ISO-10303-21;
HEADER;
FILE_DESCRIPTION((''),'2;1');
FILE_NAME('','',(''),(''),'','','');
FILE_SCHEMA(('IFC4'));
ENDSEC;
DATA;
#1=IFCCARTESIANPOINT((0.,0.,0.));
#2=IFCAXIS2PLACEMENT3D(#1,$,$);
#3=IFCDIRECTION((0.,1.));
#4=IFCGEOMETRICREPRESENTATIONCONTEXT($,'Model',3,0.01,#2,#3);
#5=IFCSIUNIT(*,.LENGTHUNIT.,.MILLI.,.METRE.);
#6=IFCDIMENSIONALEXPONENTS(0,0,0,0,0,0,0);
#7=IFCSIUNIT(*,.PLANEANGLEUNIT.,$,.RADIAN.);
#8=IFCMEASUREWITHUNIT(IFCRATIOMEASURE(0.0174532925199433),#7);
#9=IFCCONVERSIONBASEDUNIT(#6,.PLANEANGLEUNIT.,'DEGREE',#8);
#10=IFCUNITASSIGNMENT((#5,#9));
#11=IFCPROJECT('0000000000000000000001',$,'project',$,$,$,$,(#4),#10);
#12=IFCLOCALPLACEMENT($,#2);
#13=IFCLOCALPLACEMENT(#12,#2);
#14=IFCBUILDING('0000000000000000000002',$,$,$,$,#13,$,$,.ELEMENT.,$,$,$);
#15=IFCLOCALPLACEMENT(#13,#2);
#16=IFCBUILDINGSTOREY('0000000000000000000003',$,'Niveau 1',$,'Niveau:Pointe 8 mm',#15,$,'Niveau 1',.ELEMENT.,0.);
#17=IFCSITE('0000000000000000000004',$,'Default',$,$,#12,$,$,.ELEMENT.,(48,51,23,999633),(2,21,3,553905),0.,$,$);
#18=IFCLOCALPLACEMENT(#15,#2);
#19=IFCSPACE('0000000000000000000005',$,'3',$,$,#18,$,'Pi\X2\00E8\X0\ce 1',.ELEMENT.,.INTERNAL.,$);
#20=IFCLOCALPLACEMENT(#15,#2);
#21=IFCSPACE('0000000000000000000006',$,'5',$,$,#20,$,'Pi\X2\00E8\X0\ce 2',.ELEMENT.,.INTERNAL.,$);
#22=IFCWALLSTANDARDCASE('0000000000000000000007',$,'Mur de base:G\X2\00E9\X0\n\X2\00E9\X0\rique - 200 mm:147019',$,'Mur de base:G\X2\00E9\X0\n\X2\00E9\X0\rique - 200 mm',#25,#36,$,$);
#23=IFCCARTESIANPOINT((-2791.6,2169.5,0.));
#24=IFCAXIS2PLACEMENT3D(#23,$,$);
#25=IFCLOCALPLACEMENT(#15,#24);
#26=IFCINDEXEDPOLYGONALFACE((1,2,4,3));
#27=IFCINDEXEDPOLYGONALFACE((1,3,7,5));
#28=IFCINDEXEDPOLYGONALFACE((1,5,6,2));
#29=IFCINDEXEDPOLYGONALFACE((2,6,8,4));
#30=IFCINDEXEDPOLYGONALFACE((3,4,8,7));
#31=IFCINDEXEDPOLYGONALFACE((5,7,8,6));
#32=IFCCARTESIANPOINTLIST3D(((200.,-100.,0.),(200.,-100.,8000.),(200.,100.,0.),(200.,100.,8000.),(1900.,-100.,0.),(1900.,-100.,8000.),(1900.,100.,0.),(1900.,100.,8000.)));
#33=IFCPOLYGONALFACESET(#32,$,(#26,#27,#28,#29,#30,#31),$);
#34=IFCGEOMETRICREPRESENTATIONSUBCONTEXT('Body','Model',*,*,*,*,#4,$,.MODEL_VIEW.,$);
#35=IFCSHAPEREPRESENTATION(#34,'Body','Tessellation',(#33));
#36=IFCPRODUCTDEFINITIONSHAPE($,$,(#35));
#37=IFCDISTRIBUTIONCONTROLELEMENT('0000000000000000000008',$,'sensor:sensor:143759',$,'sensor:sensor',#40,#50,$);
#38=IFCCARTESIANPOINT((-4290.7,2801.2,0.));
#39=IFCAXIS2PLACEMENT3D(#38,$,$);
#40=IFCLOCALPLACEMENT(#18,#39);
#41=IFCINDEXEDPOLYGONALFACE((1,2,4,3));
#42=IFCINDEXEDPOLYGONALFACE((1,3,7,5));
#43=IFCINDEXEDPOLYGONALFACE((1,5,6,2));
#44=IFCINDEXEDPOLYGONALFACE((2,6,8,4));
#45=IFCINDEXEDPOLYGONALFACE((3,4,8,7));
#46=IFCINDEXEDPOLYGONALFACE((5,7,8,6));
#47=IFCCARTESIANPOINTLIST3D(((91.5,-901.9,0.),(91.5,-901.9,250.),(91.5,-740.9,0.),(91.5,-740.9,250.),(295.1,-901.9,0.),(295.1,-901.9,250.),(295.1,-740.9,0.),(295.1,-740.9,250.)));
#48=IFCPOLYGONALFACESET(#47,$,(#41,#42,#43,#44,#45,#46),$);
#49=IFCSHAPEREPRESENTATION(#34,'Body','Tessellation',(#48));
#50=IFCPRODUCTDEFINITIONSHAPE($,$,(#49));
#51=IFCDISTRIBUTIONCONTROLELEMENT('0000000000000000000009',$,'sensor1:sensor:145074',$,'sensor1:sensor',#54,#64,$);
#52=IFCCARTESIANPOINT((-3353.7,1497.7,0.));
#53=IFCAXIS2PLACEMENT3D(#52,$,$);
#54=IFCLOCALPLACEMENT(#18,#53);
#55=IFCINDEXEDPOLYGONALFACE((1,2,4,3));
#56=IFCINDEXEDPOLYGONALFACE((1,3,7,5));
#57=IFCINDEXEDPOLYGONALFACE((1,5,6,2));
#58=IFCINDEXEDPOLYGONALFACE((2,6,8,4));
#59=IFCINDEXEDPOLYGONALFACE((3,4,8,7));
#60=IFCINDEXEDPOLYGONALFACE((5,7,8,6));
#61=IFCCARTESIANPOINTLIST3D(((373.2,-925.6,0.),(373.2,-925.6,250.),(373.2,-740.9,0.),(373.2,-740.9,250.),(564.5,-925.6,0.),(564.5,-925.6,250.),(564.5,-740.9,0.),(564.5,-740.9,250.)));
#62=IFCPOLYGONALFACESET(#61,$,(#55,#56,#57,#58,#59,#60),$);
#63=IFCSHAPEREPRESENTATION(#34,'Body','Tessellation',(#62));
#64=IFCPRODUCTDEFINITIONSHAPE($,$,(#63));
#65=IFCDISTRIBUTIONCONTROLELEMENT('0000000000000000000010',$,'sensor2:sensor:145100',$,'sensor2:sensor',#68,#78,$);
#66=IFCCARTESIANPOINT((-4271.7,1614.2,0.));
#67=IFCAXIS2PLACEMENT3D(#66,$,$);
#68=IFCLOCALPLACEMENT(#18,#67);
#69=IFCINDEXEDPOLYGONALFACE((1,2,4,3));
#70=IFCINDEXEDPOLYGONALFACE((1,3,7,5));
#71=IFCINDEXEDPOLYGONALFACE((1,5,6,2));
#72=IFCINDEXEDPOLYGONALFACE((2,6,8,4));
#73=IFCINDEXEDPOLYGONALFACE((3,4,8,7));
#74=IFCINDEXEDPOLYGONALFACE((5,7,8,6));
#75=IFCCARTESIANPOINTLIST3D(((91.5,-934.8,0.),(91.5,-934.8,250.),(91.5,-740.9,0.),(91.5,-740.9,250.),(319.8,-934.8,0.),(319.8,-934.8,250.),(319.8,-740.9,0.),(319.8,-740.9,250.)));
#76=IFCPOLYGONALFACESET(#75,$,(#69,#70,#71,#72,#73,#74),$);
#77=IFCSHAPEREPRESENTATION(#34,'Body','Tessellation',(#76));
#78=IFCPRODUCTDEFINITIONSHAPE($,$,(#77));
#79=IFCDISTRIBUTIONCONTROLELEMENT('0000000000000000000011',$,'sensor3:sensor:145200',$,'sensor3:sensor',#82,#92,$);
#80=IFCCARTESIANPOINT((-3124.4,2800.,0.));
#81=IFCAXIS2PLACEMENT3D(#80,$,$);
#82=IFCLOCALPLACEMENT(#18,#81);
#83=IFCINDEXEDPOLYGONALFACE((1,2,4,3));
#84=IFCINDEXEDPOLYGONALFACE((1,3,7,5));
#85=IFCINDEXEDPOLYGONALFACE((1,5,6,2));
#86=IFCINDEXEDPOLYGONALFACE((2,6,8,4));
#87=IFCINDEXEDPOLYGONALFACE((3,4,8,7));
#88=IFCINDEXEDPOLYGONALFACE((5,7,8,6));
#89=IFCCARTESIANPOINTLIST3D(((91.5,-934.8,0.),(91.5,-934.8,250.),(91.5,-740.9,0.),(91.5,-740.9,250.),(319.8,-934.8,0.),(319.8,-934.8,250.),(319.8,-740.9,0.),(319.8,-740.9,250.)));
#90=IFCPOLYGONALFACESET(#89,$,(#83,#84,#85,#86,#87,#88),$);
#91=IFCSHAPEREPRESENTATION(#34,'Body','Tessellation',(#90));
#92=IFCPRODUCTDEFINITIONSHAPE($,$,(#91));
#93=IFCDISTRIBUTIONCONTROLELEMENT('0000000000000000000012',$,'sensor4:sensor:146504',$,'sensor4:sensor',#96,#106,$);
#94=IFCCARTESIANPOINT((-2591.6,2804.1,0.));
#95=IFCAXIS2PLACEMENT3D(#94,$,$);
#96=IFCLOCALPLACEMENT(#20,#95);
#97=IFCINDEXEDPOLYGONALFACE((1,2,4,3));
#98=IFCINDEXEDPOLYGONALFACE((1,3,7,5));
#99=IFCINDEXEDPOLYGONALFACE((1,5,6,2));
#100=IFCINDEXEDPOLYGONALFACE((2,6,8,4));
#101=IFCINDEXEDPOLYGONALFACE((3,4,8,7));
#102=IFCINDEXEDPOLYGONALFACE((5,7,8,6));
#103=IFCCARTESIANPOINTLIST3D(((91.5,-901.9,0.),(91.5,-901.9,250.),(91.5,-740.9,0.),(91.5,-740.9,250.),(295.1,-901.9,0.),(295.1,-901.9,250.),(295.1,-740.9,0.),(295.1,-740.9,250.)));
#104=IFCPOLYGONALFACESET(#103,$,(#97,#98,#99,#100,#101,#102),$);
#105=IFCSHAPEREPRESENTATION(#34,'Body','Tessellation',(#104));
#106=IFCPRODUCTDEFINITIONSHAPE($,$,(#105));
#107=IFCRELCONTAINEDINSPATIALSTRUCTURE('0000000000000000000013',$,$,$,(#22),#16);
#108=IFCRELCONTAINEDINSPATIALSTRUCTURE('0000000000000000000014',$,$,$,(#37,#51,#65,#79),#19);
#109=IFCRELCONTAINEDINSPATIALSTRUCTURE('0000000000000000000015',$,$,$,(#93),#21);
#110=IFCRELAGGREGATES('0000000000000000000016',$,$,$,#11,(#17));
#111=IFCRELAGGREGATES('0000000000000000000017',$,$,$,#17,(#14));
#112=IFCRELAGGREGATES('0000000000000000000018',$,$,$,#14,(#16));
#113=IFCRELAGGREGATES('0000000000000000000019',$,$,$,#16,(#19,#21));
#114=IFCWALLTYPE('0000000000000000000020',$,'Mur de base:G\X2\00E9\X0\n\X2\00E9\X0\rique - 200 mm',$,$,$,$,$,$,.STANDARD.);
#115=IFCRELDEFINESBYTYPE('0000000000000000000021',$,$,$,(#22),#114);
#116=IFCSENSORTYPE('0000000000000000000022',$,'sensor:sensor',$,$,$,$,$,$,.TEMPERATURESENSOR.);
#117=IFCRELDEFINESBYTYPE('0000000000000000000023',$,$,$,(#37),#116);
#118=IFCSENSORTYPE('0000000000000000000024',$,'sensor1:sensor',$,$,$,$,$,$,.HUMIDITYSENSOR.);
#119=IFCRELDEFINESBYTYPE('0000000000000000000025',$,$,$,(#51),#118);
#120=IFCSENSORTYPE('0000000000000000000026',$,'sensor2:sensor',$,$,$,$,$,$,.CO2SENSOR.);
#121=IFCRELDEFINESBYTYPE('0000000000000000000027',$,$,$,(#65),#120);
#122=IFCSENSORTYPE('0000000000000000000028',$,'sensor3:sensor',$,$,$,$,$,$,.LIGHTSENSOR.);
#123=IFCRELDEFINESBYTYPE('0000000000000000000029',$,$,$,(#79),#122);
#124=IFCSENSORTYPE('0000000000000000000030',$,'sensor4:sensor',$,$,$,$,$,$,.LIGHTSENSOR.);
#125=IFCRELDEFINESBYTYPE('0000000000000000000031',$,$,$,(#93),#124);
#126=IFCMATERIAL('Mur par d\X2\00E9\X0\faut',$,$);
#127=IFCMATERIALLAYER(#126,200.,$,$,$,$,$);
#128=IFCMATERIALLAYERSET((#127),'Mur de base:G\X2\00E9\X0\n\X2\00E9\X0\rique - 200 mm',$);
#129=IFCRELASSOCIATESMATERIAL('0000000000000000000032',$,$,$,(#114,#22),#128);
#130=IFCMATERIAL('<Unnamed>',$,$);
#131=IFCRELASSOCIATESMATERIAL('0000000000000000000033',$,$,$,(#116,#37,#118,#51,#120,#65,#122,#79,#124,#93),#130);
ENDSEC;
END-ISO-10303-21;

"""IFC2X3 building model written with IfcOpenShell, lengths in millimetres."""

from ifc_helpers import new_model, entity, si_unit, converted_unit, direction, frame, frame_2d, origin, origin_2d_with_axis, place, context, subcontext, project, spatial, rectangle, extrude, source, transform, mapped, material, layer, layer_set, layer_usage, type_object, type_shapes, element, save


model = new_model("IFC2X3")

# Units and contexts
model_context = context("Model", 3, precision=0.01, world=origin(), true_north=direction((0.0, 1.0)))
body_context = subcontext(model_context, "Body", "Model", "MODEL_VIEW")
ifc_project = project(units=[si_unit("LENGTHUNIT", "METRE", prefix="MILLI"), converted_unit("PLANEANGLEUNIT", "DEGREE", entity("IfcRatioMeasure", 0.0174532925199433), si_unit("PLANEANGLEUNIT", "RADIAN"), dimensions=[0, 0, 0, 0, 0, 0, 0])], contexts=[model_context])

# Site, building, storey
site_placement = place(None, origin())
site = spatial("IfcSite", under=ifc_project, at=site_placement, Name="Default", CompositionType="ELEMENT", RefLatitude=(48, 51, 23, 999633), RefLongitude=(2, 21, 3, 553905), RefElevation=0.0)
building_placement = place(site_placement, origin())
building = spatial("IfcBuilding", under=site, at=building_placement, CompositionType="ELEMENT")
storey_placement = place(building_placement, origin())
storey = spatial("IfcBuildingStorey", under=building, at=storey_placement, Name="Niveau 1", ObjectType="Niveau:Pointe 8 mm", LongName="Niveau 1", CompositionType="ELEMENT", Elevation=0.0)

# Wall
ifc_material_1 = material(Name="Mur par défaut")
ifc_layer_1 = layer(ifc_material_1, 200.0)
ifc_layer_set_1 = layer_set([ifc_layer_1], Name="Mur de base:Générique - 200 mm")
wall_type = type_object("IfcWallType", Name="Mur de base:Générique - 200 mm", PredefinedType="STANDARD", material=ifc_layer_set_1)
ifc_layer_usage_1 = layer_usage(ifc_layer_set_1, "AXIS2", "NEGATIVE", 100.0)
wall_1_placement = place(storey_placement, frame((-2791.6, 2169.5, 0.0)))
element("IfcWallStandardCase", 1, at=wall_1_placement, inside=storey, type_object=wall_type, material=ifc_layer_usage_1, Name="Mur de base:Générique - 200 mm:147019", ObjectType="Mur de base:Générique - 200 mm", context=body_context, shape_type="SweptSolid", body=[
    extrude(rectangle(XDim=1700.0, YDim=200.0, at=frame_2d((1050.0, 0.0), x_axis=(-1.0, 0.0))), origin(), (0.0, 0.0, 1.0), 8000.0),
])

# Shared definitions
space_1_placement = place(storey_placement, origin())
space_1 = spatial("IfcSpace", under=storey, at=space_1_placement, Name="3", LongName="Pièce 1", CompositionType="ELEMENT", InteriorOrExteriorSpace="INTERNAL")

# Distribution control elements
ifc_material_2 = material(Name="<Unnamed>")
sensor_type_1 = type_object("IfcSensorType", Name="sensor:sensor", PredefinedType="TEMPERATURESENSOR", material=ifc_material_2)
shared_shape_1 = source(origin(), body_context, "Body", "SweptSolid", [
    extrude(rectangle(XDim=203.6, YDim=161.0, at=origin_2d_with_axis()), frame((193.3, -821.4, 0.0), z_axis=(0.0, 0.0, 1.0), x_axis=(-1.0, 0.0, 0.0)), (0.0, 0.0, 1.0), 250.0),
])
type_shapes(sensor_type_1, [shared_shape_1])
distribution_control_element_1_placement = place(space_1_placement, frame((-4290.7, 2801.2, 0.0)))
element("IfcDistributionControlElement", 2, at=distribution_control_element_1_placement, inside=space_1, type_object=sensor_type_1, material=ifc_material_2, Name="sensor:sensor:143759", ObjectType="sensor:sensor", context=body_context, shape_type="MappedRepresentation", body=[
    mapped(shared_shape_1, transform((0.0, 0.0, 0.0), scale=1.0)),
])
sensor_type_2 = type_object("IfcSensorType", Name="sensor1:sensor", PredefinedType="HUMIDITYSENSOR", material=ifc_material_2)
shared_shape_2 = source(origin(), body_context, "Body", "SweptSolid", [
    extrude(rectangle(XDim=191.3, YDim=184.7, at=origin_2d_with_axis()), frame((468.8, -833.2, 0.0), z_axis=(0.0, 0.0, 1.0), x_axis=(-1.0, 0.0, 0.0)), (0.0, 0.0, 1.0), 250.0),
])
type_shapes(sensor_type_2, [shared_shape_2])
distribution_control_element_2_placement = place(space_1_placement, frame((-3353.7, 1497.7, 0.0)))
element("IfcDistributionControlElement", 3, at=distribution_control_element_2_placement, inside=space_1, type_object=sensor_type_2, material=ifc_material_2, Name="sensor1:sensor:145074", ObjectType="sensor1:sensor", context=body_context, shape_type="MappedRepresentation", body=[
    mapped(shared_shape_2, transform((0.0, 0.0, 0.0), scale=1.0)),
])
sensor_type_3 = type_object("IfcSensorType", Name="sensor2:sensor", PredefinedType="CO2SENSOR", material=ifc_material_2)
shared_shape_3 = source(origin(), body_context, "Body", "SweptSolid", [
    extrude(rectangle(XDim=228.4, YDim=193.9, at=origin_2d_with_axis()), frame((205.7, -837.9, 0.0), z_axis=(0.0, 0.0, 1.0), x_axis=(-1.0, 0.0, 0.0)), (0.0, 0.0, 1.0), 250.0),
])
type_shapes(sensor_type_3, [shared_shape_3])
distribution_control_element_3_placement = place(space_1_placement, frame((-4271.7, 1614.2, 0.0)))
element("IfcDistributionControlElement", 4, at=distribution_control_element_3_placement, inside=space_1, type_object=sensor_type_3, material=ifc_material_2, Name="sensor2:sensor:145100", ObjectType="sensor2:sensor", context=body_context, shape_type="MappedRepresentation", body=[
    mapped(shared_shape_3, transform((0.0, 0.0, 0.0), scale=1.0)),
])
sensor_type_4 = type_object("IfcSensorType", Name="sensor3:sensor", PredefinedType="LIGHTSENSOR", material=ifc_material_2)
shared_shape_4 = source(origin(), body_context, "Body", "SweptSolid", [
    extrude(rectangle(XDim=228.4, YDim=193.9, at=origin_2d_with_axis()), frame((205.7, -837.9, 0.0), z_axis=(0.0, 0.0, 1.0), x_axis=(-1.0, 0.0, 0.0)), (0.0, 0.0, 1.0), 250.0),
])
type_shapes(sensor_type_4, [shared_shape_4])
distribution_control_element_4_placement = place(space_1_placement, frame((-3124.4, 2800.0, 0.0)))
element("IfcDistributionControlElement", 5, at=distribution_control_element_4_placement, inside=space_1, type_object=sensor_type_4, material=ifc_material_2, Name="sensor3:sensor:145200", ObjectType="sensor3:sensor", context=body_context, shape_type="MappedRepresentation", body=[
    mapped(shared_shape_4, transform((0.0, 0.0, 0.0), scale=1.0)),
])

# Shared definitions
space_2_placement = place(storey_placement, origin())
space_2 = spatial("IfcSpace", under=storey, at=space_2_placement, Name="5", LongName="Pièce 2", CompositionType="ELEMENT", InteriorOrExteriorSpace="INTERNAL")

# Distribution control element
sensor_type_5 = type_object("IfcSensorType", Name="sensor4:sensor", PredefinedType="LIGHTSENSOR", material=ifc_material_2)
shared_shape_5 = source(origin(), body_context, "Body", "SweptSolid", [
    extrude(rectangle(XDim=203.6, YDim=161.0, at=origin_2d_with_axis()), frame((193.3, -821.4, 0.0), z_axis=(0.0, 0.0, 1.0), x_axis=(-1.0, 0.0, 0.0)), (0.0, 0.0, 1.0), 250.0),
])
type_shapes(sensor_type_5, [shared_shape_5])
distribution_control_element_5_placement = place(space_2_placement, frame((-2591.6, 2804.1, 0.0)))
element("IfcDistributionControlElement", 6, at=distribution_control_element_5_placement, inside=space_2, type_object=sensor_type_5, material=ifc_material_2, Name="sensor4:sensor:146504", ObjectType="sensor4:sensor", context=body_context, shape_type="MappedRepresentation", body=[
    mapped(shared_shape_5, transform((0.0, 0.0, 0.0), scale=1.0)),
])

save(model, "model.ifc")
